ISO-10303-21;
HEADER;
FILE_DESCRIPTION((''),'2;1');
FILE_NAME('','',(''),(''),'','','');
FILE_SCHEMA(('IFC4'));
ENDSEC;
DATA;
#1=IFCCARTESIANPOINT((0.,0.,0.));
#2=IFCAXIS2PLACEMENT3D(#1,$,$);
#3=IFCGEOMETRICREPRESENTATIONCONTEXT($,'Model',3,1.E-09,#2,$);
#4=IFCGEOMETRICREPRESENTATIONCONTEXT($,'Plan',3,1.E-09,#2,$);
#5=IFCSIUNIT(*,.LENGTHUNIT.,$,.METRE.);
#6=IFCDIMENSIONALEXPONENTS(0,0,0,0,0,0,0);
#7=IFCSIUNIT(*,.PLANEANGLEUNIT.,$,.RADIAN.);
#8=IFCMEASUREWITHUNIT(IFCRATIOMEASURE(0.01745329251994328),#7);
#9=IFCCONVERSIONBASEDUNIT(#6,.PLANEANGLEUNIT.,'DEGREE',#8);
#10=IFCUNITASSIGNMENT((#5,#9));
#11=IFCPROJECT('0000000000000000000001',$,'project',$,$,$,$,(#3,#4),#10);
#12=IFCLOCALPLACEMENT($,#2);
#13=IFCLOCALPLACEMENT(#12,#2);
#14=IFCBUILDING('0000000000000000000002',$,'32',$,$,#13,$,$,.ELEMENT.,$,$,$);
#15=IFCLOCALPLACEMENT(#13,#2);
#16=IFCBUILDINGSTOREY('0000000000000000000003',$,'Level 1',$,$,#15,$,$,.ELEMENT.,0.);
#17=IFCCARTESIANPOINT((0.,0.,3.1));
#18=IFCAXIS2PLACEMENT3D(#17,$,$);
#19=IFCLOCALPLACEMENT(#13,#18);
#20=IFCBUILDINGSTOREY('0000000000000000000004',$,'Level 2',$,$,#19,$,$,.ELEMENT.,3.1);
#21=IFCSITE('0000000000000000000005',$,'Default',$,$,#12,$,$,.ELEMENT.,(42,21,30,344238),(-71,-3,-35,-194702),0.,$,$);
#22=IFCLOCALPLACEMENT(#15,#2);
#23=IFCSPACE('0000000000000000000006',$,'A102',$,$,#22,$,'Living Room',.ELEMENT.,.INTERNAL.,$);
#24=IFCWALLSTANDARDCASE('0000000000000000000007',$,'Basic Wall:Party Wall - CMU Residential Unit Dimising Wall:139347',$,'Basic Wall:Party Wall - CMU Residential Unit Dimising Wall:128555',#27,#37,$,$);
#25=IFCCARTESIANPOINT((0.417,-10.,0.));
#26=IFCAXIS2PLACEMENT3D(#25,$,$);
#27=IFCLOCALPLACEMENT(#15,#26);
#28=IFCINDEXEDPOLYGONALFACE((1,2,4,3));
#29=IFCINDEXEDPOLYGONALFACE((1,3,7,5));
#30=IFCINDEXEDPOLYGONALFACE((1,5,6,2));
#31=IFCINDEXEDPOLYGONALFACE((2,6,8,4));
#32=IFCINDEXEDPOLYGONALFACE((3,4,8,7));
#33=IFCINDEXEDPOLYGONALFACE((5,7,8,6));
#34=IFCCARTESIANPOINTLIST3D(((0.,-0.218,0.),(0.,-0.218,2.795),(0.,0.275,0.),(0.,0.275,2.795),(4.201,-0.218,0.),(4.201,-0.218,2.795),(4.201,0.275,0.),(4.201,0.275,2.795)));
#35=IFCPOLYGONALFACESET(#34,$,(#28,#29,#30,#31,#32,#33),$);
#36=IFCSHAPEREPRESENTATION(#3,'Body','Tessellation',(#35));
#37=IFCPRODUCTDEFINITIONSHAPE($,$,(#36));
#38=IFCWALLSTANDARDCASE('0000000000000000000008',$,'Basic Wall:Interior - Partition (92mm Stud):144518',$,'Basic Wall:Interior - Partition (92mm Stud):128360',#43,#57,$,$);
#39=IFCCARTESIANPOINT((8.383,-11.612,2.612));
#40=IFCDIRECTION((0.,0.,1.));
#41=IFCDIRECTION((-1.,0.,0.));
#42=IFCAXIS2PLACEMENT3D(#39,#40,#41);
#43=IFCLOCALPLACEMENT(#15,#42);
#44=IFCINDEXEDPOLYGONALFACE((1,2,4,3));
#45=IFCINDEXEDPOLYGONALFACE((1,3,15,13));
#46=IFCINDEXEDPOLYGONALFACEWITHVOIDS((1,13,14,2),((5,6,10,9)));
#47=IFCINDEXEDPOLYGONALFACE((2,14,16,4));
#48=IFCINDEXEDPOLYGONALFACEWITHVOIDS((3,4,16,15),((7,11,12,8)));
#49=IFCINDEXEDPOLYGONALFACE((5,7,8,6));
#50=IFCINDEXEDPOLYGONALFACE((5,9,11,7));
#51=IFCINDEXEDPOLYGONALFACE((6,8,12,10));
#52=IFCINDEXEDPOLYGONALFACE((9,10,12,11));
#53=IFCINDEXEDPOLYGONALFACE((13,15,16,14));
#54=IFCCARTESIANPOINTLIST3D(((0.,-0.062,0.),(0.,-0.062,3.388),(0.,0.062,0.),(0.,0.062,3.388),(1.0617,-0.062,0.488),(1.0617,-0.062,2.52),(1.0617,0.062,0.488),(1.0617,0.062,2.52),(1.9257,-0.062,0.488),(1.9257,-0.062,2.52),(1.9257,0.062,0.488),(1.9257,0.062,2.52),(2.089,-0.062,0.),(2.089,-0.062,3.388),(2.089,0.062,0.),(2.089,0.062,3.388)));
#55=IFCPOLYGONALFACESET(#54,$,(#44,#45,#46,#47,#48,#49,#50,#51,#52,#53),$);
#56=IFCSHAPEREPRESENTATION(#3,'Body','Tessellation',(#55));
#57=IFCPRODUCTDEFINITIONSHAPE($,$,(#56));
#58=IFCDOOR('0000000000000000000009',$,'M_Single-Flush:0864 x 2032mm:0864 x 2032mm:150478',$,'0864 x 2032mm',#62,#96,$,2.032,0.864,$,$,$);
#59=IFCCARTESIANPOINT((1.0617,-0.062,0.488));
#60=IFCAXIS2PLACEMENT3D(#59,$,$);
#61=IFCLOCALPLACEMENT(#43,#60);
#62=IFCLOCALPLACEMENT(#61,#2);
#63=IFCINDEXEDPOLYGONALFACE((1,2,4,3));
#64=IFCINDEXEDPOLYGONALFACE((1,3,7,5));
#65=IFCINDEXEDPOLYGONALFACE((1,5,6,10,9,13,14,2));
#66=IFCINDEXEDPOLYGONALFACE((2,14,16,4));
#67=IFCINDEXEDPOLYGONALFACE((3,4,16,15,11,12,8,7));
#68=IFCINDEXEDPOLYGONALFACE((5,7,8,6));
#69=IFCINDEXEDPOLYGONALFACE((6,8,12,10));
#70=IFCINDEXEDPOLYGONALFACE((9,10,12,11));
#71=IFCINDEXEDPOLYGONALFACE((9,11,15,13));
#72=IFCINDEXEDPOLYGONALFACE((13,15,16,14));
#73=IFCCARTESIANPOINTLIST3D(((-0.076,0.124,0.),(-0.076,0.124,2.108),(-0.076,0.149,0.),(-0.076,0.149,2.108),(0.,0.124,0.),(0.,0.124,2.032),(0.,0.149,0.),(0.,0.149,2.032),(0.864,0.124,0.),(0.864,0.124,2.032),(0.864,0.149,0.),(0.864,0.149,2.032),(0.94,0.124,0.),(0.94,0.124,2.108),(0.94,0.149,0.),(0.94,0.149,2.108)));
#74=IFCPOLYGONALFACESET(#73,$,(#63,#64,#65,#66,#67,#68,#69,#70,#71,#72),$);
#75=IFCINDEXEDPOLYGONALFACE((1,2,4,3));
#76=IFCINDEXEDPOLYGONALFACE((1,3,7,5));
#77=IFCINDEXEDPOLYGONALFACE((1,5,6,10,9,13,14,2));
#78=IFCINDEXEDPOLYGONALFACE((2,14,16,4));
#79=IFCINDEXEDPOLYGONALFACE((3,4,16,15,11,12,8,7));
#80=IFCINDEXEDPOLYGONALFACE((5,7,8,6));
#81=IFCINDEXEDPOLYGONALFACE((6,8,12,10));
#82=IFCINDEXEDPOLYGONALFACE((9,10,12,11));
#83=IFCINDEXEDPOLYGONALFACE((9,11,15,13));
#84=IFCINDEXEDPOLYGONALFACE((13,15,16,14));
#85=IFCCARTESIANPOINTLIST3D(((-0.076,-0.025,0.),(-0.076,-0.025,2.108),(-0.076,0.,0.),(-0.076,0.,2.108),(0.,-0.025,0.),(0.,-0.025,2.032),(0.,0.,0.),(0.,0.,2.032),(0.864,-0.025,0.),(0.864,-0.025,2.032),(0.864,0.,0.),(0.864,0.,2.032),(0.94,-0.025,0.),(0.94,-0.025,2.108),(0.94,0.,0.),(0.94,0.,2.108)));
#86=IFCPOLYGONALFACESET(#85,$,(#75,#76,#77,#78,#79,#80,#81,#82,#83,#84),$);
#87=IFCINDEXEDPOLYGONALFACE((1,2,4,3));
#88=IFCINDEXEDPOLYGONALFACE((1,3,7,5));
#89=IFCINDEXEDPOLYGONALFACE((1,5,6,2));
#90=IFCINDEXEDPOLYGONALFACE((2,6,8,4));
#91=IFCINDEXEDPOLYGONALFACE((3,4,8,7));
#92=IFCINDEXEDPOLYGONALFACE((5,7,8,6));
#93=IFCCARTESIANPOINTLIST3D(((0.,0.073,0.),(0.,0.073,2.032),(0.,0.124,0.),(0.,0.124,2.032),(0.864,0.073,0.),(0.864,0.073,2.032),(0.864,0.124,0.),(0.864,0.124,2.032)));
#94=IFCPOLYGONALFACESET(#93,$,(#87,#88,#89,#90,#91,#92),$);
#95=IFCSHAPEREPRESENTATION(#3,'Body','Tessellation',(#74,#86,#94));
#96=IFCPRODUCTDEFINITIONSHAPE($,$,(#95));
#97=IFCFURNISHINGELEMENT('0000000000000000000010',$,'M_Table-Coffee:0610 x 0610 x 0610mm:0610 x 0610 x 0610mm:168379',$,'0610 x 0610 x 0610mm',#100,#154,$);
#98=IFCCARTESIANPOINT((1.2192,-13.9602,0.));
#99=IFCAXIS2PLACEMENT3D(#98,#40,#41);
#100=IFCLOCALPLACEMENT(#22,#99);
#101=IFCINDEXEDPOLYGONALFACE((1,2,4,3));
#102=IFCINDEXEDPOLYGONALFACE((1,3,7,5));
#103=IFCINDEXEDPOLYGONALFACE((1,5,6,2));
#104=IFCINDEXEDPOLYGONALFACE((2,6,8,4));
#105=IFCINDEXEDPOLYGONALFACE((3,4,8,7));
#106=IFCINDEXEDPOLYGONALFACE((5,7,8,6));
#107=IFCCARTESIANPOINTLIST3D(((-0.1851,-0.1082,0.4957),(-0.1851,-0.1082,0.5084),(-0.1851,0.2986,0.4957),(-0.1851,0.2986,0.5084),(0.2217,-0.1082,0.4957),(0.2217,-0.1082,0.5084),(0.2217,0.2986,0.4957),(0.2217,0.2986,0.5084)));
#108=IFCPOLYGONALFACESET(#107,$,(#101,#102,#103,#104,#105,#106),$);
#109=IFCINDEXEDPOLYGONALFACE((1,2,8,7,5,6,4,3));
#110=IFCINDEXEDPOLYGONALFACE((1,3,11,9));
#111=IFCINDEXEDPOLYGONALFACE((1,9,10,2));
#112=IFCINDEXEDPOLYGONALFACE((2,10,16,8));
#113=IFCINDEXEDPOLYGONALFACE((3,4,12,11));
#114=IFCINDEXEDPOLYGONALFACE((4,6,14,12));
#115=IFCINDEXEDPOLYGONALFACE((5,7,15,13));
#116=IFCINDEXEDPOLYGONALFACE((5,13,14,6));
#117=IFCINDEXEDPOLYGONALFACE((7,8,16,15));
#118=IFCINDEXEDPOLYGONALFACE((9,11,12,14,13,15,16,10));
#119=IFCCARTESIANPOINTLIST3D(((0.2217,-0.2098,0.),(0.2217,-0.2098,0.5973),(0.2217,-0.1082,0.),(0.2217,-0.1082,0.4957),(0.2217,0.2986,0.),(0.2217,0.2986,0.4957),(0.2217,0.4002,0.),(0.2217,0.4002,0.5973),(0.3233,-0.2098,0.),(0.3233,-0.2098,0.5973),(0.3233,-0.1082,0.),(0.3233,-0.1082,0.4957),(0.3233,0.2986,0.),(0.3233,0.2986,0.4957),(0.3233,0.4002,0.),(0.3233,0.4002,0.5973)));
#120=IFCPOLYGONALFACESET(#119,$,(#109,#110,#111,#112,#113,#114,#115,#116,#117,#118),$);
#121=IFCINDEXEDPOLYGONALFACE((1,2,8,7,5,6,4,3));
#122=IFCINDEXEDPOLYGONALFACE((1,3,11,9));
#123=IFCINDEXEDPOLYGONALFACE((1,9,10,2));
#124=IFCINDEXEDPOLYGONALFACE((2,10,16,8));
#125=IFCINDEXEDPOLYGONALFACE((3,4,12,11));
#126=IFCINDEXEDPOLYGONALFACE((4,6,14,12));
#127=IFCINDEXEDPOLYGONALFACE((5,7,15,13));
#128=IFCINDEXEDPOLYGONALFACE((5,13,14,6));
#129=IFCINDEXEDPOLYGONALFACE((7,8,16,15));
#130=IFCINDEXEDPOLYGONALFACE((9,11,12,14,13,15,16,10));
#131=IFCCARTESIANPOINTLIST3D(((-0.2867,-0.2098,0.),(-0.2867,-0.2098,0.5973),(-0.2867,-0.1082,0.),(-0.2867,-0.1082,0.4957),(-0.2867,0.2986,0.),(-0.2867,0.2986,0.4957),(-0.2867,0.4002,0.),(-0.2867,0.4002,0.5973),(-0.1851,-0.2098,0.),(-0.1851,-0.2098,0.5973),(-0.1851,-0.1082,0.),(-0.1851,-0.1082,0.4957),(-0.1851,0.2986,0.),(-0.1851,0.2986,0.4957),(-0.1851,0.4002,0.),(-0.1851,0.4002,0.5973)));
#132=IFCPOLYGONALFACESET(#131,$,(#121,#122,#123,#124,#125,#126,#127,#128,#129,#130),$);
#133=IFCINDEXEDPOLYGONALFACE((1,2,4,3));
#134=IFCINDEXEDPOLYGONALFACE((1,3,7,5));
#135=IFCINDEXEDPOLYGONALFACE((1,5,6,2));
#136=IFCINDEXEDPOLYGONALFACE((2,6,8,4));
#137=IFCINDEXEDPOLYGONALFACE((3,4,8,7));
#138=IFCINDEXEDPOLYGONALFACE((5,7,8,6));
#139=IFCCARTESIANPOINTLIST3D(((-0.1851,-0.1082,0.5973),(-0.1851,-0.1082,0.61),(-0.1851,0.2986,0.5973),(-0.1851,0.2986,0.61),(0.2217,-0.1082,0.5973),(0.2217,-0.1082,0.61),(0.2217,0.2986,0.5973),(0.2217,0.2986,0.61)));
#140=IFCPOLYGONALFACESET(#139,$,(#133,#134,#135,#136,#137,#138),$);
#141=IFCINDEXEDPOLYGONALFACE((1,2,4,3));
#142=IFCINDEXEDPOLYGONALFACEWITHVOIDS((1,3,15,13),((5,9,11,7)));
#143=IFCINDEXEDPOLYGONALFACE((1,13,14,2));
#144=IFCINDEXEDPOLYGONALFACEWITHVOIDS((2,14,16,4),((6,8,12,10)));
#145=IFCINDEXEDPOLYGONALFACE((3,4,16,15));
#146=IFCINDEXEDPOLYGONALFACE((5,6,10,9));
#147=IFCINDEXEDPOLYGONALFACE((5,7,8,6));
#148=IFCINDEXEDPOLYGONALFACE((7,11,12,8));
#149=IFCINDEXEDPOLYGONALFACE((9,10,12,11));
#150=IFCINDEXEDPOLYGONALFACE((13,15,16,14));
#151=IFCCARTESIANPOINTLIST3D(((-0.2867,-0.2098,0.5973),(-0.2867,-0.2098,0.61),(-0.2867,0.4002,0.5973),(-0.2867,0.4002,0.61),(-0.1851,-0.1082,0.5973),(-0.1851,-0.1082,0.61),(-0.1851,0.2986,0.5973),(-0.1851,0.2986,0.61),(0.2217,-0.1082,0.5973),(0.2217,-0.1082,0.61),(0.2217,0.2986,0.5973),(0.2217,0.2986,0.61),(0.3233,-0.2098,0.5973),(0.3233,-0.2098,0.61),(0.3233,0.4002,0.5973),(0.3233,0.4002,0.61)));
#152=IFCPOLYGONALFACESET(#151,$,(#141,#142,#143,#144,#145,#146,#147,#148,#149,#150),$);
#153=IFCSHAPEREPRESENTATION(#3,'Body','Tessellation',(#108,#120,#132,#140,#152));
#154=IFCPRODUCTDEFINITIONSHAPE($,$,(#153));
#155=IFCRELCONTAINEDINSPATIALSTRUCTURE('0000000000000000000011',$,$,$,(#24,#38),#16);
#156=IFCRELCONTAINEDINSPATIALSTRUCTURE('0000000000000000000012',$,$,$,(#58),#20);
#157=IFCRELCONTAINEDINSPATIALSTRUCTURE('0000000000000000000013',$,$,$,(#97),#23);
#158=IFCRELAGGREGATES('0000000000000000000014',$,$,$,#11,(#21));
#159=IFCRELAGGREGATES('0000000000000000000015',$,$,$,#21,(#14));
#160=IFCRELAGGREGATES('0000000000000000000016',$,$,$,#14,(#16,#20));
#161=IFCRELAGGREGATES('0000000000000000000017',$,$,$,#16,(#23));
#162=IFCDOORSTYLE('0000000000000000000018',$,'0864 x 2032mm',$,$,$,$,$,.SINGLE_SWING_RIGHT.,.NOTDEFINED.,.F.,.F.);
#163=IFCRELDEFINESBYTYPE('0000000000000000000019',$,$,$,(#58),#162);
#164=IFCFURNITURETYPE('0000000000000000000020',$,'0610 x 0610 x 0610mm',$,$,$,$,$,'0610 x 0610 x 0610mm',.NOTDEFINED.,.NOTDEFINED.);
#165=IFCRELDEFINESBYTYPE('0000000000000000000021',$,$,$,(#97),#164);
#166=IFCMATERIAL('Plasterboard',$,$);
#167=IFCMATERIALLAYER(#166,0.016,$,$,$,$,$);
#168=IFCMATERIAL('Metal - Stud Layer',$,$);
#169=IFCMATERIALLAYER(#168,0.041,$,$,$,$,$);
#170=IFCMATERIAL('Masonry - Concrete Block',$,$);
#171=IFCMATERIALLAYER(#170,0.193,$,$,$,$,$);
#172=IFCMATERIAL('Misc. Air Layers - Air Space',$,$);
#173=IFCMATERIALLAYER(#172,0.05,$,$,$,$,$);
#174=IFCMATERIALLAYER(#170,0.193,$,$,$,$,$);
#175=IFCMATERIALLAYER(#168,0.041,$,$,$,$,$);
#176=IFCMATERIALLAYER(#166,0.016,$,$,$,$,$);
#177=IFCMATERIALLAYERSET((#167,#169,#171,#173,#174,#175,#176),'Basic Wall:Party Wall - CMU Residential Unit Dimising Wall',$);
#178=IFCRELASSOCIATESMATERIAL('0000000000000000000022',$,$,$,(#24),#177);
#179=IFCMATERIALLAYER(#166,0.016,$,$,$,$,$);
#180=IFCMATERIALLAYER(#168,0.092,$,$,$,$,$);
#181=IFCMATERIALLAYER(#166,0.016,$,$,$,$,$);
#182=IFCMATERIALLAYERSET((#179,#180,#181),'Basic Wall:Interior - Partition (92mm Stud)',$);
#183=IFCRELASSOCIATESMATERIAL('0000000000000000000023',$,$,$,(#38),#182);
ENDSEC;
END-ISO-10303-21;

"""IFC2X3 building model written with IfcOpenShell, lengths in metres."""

from ifc_helpers import new_model, entity, si_unit, converted_unit, frame, frame_2d, origin, origin_2d_with_axis, place, context, project, spatial, polyline, rectangle, outline, extrude, clip, bounded_halfspace, source, transform, mapped, material, layer, layer_set, layer_usage, type_object, type_shapes, element, fill, save


model = new_model("IFC2X3")

# Units and contexts
model_context = context("Model", 3, precision=1e-09, world=origin())
plan_context = context("Plan", 3, precision=1e-09, world=origin())
ifc_project = project(units=[si_unit("LENGTHUNIT", "METRE"), converted_unit("PLANEANGLEUNIT", "DEGREE", entity("IfcRatioMeasure", 0.01745329251994328), si_unit("PLANEANGLEUNIT", "RADIAN"), dimensions=[0, 0, 0, 0, 0, 0, 0])], contexts=[model_context, plan_context])

# Site, building, storey
site_placement = place(None, origin())
site = spatial("IfcSite", under=ifc_project, at=site_placement, Name="Default", CompositionType="ELEMENT", RefLatitude=(42, 21, 30, 344238), RefLongitude=(-71, -3, -35, -194702), RefElevation=0.0)
building_placement = place(site_placement, origin())
building = spatial("IfcBuilding", under=site, at=building_placement, Name="32", CompositionType="ELEMENT")
storey_1_placement = place(building_placement, origin())
storey_1 = spatial("IfcBuildingStorey", under=building, at=storey_1_placement, Name="Level 1", CompositionType="ELEMENT", Elevation=0.0)

# Shared definitions
ifc_material_1 = material(Name="Misc. Air Layers - Air Space")
ifc_material_2 = material(Name="Masonry - Concrete Block")
ifc_material_3 = material(Name="Metal - Stud Layer")
ifc_material_4 = material(Name="Plasterboard")

# Wall
ifc_layer_1 = layer(ifc_material_4, 0.016)
ifc_layer_2 = layer(ifc_material_3, 0.041)
ifc_layer_3 = layer(ifc_material_2, 0.193)
ifc_layer_4 = layer(ifc_material_1, 0.05)
ifc_layer_5 = layer(ifc_material_2, 0.193)
ifc_layer_6 = layer(ifc_material_3, 0.041)
ifc_layer_7 = layer(ifc_material_4, 0.016)
ifc_layer_set_1 = layer_set([ifc_layer_1, ifc_layer_2, ifc_layer_3, ifc_layer_4, ifc_layer_5, ifc_layer_6, ifc_layer_7], Name="Basic Wall:Party Wall - CMU Residential Unit Dimising Wall")
ifc_layer_usage_1 = layer_usage(ifc_layer_set_1, "AXIS2", "NEGATIVE", 0.275)
wall_1_placement = place(storey_1_placement, frame((0.417, -10.0, 0.0)))
element("IfcWallStandardCase", 1, at=wall_1_placement, inside=storey_1, material=ifc_layer_usage_1, Name="Basic Wall:Party Wall - CMU Residential Unit Dimising Wall:139347", ObjectType="Basic Wall:Party Wall - CMU Residential Unit Dimising Wall:128555", context=model_context, shape_type="Clipping", body=[
    clip(clip(extrude(rectangle(XDim=4.201, YDim=0.55, at=frame_2d((2.1005, 0.0), x_axis=(-1.0, 0.0))), origin(), (0.0, 0.0, 1.0), 2.795), bounded_halfspace(frame((0.0, -0.218, 0.0), z_axis=(0.0, 1.0, 0.0), x_axis=(-1.0, 0.0, 0.0)), True, frame((0.0, -0.218, 0.0), z_axis=(0.0, 1.0, 0.0), x_axis=(-1.0, 0.0, 0.0)), polyline([(0.0, 0.0), (0.0, 2.795), (-4.201, 2.795), (-4.201, 0.0), (0.0, 0.0)]))), bounded_halfspace(frame((4.201, 0.275, 0.0), z_axis=(-1.0, 0.0, 0.0), x_axis=(0.0, -1.0, 0.0)), True, frame((4.201, 0.275, 0.0), z_axis=(-1.0, 0.0, 0.0), x_axis=(0.0, -1.0, 0.0)), polyline([(0.0, 0.0), (0.493, 0.0), (0.493, 2.795), (0.0, 2.795), (0.0, 0.0)]))),
])

# Shared definitions
ifc_layer_8 = layer(ifc_material_4, 0.016)
ifc_layer_9 = layer(ifc_material_3, 0.092)
ifc_layer_10 = layer(ifc_material_4, 0.016)
ifc_layer_set_2 = layer_set([ifc_layer_8, ifc_layer_9, ifc_layer_10], Name="Basic Wall:Interior - Partition (92mm Stud)")

# Wall, opening
ifc_layer_usage_2 = layer_usage(ifc_layer_set_2, "AXIS2", "NEGATIVE", 0.062)
wall_2_placement = place(storey_1_placement, frame((8.383, -11.612, 2.612), z_axis=(0.0, 0.0, 1.0), x_axis=(-1.0, 0.0, 0.0)))
wall_2 = element("IfcWallStandardCase", 2, at=wall_2_placement, inside=storey_1, material=ifc_layer_usage_2, Name="Basic Wall:Interior - Partition (92mm Stud):144518", ObjectType="Basic Wall:Interior - Partition (92mm Stud):128360", context=model_context, shape_type="SweptSolid", body=[
    extrude(rectangle(XDim=2.089, YDim=0.124, at=frame_2d((1.0445, 0.0), x_axis=(-1.0, 0.0))), origin(), (0.0, 0.0, 1.0), 3.388),
])
opening_1_placement = place(wall_2_placement, frame((1.0617, -0.062, 0.488)))
opening_1 = element("IfcOpeningElement", 3, at=opening_1_placement, cuts=wall_2, ObjectType="Opening", context=model_context, shape_type="SweptSolid", body=[
    extrude(rectangle(XDim=0.864, YDim=2.032, at=frame_2d((1.016, 0.432), x_axis=(0.0, 1.0))), frame((0.0, 0.0, 0.0), z_axis=(0.0, 1.0, 0.0), x_axis=(0.0, 0.0, 1.0)), (0.0, 0.0, 1.0), 0.124),
])

# Shared definitions
storey_2_placement = place(building_placement, frame((0.0, 0.0, 3.1)))
storey_2 = spatial("IfcBuildingStorey", under=building, at=storey_2_placement, Name="Level 2", CompositionType="ELEMENT", Elevation=3.1)

# Door
door_style_1 = type_object("IfcDoorStyle", Name="0864 x 2032mm", ConstructionType="NOTDEFINED", OperationType="SINGLE_SWING_RIGHT", ParameterTakesPrecedence=False, Sizeable=False)
shared_shape_1 = source(origin(), model_context, "Body", "SweptSolid", [
    extrude(outline(polyline([(-0.508, -1.073), (0.508, -1.073), (0.508, 1.035), (0.432, 1.035), (0.432, -0.997), (-0.432, -0.997), (-0.432, 1.035), (-0.508, 1.035), (-0.508, -1.073)])), frame((0.432, 0.124, 1.035), z_axis=(0.0, 1.0, 0.0), x_axis=(1.0, 0.0, 0.0)), (0.0, 0.0, 1.0), 0.025),
    extrude(outline(polyline([(-1.073, -0.508), (1.035, -0.508), (1.035, -0.432), (-0.997, -0.432), (-0.997, 0.432), (1.035, 0.432), (1.035, 0.508), (-1.073, 0.508), (-1.073, -0.508)])), frame((0.432, -0.025, 1.035), z_axis=(0.0, 1.0, 0.0), x_axis=(0.0, 0.0, -1.0)), (0.0, 0.0, 1.0), 0.025),
    extrude(rectangle(XDim=0.051, YDim=0.864, at=origin_2d_with_axis()), frame((0.432, 0.0985, 0.0), z_axis=(0.0, 0.0, 1.0), x_axis=(0.0, 1.0, 0.0)), (0.0, 0.0, 1.0), 2.032),
])
type_shapes(door_style_1, [shared_shape_1])
door_1_placement = place(opening_1_placement, origin())
door_1 = element("IfcDoor", 4, at=door_1_placement, inside=storey_2, type_object=door_style_1, Name="M_Single-Flush:0864 x 2032mm:0864 x 2032mm:150478", ObjectType="0864 x 2032mm", OverallHeight=2.032, OverallWidth=0.864, context=model_context, shape_type="MappedRepresentation", body=[
    mapped(shared_shape_1, transform((0.0, 0.0, 0.0), scale=1.0)),
])
fill(opening_1, door_1)

# Shared definitions
space_1_placement = place(storey_1_placement, origin())
space_1 = spatial("IfcSpace", under=storey_1, at=space_1_placement, Name="A102", LongName="Living Room", CompositionType="ELEMENT", InteriorOrExteriorSpace="INTERNAL")

# Furnishing element
furniture_type_1 = type_object("IfcFurnitureType", Name="0610 x 0610 x 0610mm", ElementType="0610 x 0610 x 0610mm", AssemblyPlace="NOTDEFINED")
shared_shape_2 = source(origin(), model_context, "Body", "SweptSolid", [
    extrude(rectangle(XDim=0.4068, YDim=0.4068, at=origin_2d_with_axis()), frame((0.0183, 0.0952, 0.4957), z_axis=(0.0, 0.0, 1.0), x_axis=(-1.0, 0.0, 0.0)), (0.0, 0.0, 1.0), 0.0127),
    extrude(outline(polyline([(-0.2732, -0.305), (0.324, -0.305), (0.324, 0.305), (-0.2732, 0.305), (-0.2732, 0.2034), (0.2225, 0.2034), (0.2225, -0.2034), (-0.2732, -0.2034), (-0.2732, -0.305)])), frame((0.2217, 0.0952, 0.2732), z_axis=(1.0, 0.0, 0.0), x_axis=(0.0, 0.0, 1.0)), (0.0, 0.0, 1.0), 0.1016),
    extrude(outline(polyline([(-0.305, -0.3241), (0.305, -0.3241), (0.305, 0.2733), (0.2034, 0.2733), (0.2034, -0.2224), (-0.2034, -0.2224), (-0.2034, 0.2733), (-0.305, 0.2733), (-0.305, -0.3241)])), frame((-0.2867, 0.0952, 0.2733), z_axis=(1.0, 0.0, 0.0), x_axis=(0.0, -1.0, 0.0)), (0.0, 0.0, 1.0), 0.1016),
    extrude(rectangle(XDim=0.4068, YDim=0.4068, at=origin_2d_with_axis()), frame((0.0183, 0.0952, 0.5973), z_axis=(0.0, 0.0, 1.0), x_axis=(-1.0, 0.0, 0.0)), (0.0, 0.0, 1.0), 0.0127),
    extrude(outline(polyline([(-0.305, -0.305), (0.305, -0.305), (0.305, 0.305), (-0.305, 0.305), (-0.305, -0.305)]), holes=[polyline([(-0.2034, -0.2034), (-0.2034, 0.2034), (0.2034, 0.2034), (0.2034, -0.2034), (-0.2034, -0.2034)])]), frame((0.0183, 0.0952, 0.5973), z_axis=(0.0, 0.0, 1.0), x_axis=(-1.0, 0.0, 0.0)), (0.0, 0.0, 1.0), 0.0127),
])
type_shapes(furniture_type_1, [shared_shape_2])
for number, where, z_axis, x_axis, name in (
    (5, (1.2192, -13.9602, 0.0), (0.0, 0.0, 1.0), (-1.0, 0.0, 0.0), "M_Table-Coffee:0610 x 0610 x 0610mm:0610 x 0610 x 0610mm:168379"),
):
    element("IfcFurnishingElement", number, at=place(space_1_placement, frame(where, z_axis=z_axis, x_axis=x_axis)), inside=space_1, type_object=furniture_type_1, Name=name, ObjectType="0610 x 0610 x 0610mm", context=model_context, shape_type="MappedRepresentation", body=[
        mapped(shared_shape_2, transform((0.0, 0.0, 0.0), scale=1.0)),
    ])

save(model, "model.ifc")
